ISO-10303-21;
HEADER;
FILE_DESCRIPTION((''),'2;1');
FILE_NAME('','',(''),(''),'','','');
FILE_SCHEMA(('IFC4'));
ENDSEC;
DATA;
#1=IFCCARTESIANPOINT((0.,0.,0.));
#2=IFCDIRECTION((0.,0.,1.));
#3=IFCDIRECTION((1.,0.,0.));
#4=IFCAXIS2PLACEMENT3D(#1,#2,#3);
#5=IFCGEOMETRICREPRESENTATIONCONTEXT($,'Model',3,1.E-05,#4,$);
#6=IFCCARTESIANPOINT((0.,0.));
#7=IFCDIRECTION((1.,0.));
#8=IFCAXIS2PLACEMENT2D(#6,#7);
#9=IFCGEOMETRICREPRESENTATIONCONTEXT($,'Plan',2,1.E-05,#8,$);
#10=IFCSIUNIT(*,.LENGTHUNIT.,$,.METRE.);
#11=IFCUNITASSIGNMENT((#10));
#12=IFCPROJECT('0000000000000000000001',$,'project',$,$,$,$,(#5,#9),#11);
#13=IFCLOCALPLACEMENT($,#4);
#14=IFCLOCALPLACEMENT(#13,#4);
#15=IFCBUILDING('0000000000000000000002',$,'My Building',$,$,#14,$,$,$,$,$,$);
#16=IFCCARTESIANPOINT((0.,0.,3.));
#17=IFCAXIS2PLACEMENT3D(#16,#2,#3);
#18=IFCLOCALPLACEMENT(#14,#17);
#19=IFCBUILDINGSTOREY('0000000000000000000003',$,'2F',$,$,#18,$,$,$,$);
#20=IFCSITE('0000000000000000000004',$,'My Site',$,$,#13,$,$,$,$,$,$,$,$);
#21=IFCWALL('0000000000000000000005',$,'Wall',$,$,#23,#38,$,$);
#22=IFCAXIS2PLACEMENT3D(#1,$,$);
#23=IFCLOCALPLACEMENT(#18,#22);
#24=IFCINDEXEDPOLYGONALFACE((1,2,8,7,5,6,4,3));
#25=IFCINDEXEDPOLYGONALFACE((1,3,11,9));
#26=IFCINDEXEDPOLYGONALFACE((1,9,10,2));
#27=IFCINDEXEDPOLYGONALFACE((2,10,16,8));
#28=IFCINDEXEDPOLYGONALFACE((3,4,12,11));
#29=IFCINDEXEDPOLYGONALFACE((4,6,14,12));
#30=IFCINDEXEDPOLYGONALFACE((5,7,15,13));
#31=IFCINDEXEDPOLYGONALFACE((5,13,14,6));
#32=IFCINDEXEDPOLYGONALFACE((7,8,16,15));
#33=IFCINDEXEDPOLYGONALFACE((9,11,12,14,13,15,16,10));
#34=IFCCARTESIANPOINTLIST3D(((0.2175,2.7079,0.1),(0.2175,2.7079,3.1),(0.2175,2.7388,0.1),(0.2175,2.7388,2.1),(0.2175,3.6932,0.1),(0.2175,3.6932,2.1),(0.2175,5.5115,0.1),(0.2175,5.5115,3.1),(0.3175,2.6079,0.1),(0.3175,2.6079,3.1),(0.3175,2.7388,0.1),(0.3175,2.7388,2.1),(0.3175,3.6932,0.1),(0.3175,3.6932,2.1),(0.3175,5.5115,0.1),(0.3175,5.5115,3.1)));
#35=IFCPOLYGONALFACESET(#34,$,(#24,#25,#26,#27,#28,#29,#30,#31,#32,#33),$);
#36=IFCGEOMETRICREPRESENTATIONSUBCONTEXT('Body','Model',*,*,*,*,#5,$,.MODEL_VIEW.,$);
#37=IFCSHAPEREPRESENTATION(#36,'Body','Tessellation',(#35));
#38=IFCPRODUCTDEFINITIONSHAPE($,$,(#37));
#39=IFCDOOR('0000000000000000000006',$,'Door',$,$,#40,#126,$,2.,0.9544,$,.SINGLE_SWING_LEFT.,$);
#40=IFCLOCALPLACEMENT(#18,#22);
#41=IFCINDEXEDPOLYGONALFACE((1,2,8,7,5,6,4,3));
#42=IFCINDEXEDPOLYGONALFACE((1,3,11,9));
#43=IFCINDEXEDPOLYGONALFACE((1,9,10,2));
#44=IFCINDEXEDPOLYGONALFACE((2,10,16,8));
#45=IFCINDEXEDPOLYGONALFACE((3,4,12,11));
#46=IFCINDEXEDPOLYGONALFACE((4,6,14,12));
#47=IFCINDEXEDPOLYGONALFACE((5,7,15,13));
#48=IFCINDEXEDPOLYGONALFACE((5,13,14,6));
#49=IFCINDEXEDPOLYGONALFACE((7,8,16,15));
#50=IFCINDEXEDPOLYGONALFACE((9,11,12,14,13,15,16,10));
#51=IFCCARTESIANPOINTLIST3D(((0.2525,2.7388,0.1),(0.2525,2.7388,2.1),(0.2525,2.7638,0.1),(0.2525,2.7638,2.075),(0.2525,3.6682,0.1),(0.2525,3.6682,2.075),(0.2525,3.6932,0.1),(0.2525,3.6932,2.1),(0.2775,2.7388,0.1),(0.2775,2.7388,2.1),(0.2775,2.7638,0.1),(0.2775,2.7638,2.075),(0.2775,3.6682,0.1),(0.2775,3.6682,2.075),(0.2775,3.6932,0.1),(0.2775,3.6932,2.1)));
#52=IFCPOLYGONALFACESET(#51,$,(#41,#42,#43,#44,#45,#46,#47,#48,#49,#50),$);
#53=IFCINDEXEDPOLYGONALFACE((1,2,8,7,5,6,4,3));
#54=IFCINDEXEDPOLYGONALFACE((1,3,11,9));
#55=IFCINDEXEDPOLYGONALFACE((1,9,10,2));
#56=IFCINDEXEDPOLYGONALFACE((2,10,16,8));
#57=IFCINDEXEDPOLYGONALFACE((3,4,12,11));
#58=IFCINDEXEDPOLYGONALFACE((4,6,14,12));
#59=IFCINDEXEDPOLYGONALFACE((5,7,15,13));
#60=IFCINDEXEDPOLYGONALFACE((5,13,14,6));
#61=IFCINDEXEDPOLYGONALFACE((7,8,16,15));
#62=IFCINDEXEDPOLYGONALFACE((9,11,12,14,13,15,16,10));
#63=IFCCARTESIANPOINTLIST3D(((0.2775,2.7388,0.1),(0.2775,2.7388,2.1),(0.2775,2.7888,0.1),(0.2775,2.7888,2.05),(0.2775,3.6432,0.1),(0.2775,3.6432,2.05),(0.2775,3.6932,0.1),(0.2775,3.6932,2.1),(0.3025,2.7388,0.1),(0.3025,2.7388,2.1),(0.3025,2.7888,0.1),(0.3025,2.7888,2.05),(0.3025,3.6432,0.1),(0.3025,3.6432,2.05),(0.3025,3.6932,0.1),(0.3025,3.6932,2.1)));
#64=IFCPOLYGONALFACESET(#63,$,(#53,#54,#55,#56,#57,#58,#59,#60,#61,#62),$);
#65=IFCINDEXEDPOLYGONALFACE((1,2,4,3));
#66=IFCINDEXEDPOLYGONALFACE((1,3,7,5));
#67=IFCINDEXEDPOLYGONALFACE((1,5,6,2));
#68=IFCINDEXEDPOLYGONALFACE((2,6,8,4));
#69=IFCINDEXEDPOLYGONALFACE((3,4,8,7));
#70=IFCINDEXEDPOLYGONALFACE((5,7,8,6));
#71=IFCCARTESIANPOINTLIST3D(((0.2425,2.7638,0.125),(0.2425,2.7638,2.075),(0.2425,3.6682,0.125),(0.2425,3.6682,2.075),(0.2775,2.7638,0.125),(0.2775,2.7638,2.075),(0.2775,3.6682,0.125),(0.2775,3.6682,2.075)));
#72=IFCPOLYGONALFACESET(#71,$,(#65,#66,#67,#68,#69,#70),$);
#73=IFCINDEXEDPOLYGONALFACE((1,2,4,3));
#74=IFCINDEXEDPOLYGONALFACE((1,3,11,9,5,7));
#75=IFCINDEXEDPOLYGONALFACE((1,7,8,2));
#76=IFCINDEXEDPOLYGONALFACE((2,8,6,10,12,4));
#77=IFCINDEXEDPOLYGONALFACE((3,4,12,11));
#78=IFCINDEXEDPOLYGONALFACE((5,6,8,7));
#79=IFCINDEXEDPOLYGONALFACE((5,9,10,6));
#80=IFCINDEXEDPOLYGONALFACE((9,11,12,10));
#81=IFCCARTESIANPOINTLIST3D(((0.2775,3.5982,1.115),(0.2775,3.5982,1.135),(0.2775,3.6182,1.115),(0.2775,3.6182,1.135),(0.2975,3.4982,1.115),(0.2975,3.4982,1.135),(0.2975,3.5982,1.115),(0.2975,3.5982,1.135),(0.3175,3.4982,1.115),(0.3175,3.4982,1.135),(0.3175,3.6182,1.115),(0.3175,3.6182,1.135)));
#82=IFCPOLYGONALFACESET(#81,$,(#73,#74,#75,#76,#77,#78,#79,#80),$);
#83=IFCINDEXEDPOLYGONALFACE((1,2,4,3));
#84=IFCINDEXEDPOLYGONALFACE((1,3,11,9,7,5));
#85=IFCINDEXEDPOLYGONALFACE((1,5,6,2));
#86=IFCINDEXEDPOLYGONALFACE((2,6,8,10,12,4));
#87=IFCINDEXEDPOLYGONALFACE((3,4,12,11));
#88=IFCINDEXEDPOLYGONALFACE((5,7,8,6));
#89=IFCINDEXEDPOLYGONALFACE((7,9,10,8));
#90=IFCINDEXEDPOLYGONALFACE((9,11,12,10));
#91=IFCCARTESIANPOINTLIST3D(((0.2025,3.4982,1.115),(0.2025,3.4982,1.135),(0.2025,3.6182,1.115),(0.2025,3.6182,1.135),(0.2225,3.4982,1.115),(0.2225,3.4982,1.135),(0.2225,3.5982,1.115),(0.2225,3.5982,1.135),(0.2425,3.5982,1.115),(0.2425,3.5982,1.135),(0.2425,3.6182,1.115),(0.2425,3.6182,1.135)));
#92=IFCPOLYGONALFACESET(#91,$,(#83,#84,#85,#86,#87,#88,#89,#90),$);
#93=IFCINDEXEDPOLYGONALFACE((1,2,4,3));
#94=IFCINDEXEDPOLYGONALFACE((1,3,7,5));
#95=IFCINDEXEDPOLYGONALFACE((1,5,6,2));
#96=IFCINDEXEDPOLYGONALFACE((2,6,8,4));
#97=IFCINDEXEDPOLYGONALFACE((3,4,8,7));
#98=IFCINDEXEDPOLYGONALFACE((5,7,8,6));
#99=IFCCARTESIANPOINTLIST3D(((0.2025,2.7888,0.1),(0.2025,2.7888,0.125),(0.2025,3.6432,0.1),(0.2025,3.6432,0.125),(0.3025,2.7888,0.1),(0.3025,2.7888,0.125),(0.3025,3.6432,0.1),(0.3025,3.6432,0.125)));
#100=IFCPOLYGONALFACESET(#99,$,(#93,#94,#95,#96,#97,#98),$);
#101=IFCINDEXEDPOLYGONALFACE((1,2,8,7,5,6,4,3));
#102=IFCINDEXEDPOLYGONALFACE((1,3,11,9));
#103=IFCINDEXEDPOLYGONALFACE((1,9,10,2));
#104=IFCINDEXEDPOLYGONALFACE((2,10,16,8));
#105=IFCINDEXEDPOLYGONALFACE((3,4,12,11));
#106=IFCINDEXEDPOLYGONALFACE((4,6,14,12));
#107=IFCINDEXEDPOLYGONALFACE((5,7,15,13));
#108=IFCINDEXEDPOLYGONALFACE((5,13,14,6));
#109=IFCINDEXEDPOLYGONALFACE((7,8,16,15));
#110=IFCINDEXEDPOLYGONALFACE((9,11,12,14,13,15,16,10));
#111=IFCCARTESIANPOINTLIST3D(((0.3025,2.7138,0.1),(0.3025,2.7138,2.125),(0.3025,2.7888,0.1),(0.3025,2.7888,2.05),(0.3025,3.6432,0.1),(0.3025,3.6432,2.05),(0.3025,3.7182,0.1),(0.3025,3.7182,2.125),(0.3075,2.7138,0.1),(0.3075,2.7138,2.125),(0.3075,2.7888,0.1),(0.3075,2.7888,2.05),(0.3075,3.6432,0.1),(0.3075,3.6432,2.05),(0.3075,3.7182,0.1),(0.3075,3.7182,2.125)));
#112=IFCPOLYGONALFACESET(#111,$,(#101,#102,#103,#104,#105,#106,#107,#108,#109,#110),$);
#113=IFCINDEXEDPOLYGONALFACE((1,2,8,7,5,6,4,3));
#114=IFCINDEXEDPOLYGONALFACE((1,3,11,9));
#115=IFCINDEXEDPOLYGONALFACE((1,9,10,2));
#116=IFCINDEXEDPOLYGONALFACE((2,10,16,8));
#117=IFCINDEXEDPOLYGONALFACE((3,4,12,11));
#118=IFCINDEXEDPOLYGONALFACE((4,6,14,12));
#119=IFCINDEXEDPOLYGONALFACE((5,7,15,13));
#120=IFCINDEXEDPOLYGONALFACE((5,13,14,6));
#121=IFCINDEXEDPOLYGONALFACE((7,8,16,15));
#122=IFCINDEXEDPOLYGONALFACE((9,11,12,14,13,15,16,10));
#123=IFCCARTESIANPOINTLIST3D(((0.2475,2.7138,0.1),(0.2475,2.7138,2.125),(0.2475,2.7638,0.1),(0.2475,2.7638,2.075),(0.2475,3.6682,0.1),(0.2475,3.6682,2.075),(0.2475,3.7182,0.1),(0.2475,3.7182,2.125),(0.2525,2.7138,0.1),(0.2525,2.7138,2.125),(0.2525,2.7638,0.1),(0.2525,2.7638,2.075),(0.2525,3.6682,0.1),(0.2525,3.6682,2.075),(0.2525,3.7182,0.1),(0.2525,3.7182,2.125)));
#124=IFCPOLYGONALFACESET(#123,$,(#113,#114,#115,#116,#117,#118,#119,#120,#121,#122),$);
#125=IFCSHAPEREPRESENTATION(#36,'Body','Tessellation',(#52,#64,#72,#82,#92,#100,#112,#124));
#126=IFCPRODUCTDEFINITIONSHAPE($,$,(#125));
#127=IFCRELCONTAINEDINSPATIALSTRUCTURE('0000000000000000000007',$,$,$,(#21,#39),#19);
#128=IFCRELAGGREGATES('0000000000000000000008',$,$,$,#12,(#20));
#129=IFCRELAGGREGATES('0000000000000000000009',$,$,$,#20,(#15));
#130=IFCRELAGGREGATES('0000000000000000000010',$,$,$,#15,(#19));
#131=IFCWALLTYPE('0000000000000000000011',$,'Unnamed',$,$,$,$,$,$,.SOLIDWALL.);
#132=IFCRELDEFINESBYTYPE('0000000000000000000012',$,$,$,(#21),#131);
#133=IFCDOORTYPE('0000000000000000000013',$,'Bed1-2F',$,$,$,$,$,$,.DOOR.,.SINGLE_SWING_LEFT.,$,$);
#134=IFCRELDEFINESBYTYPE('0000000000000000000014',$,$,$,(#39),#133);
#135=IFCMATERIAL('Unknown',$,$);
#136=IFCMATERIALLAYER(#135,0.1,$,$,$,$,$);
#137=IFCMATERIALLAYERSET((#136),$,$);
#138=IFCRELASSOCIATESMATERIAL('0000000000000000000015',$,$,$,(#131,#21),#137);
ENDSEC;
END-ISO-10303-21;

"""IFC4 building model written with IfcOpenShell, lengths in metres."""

from ifc_helpers import new_model, entity, si_unit, frame, origin_with_axes, origin_2d_with_axis, place, context, subcontext, project, spatial, line, indexed_curve, outline, extrude, shape, source, transform, mapped, material, layer, layer_set, layer_usage, type_object, type_shapes, element, fill, save


model = new_model("IFC4")

# Units and contexts
model_context = context("Model", 3, precision=1e-05, world=origin_with_axes())
plan_context = context("Plan", 2, precision=1e-05, world=origin_2d_with_axis())
body_context_1 = subcontext(model_context, "Body", "Model", "MODEL_VIEW")
body_context_2 = subcontext(plan_context, "Body", "Plan", "PLAN_VIEW")
ifc_project = project(units=[si_unit("LENGTHUNIT", "METRE")], contexts=[model_context, plan_context])

# Site, building, storey
site_placement = place(None, origin_with_axes())
site = spatial("IfcSite", under=ifc_project, at=site_placement, Name="My Site")
building_placement = place(site_placement, origin_with_axes())
building = spatial("IfcBuilding", under=site, at=building_placement, Name="My Building")
storey_placement = place(building_placement, frame((0.0, 0.0, 3.0), z_axis=(0.0, 0.0, 1.0), x_axis=(1.0, 0.0, 0.0)))
storey = spatial("IfcBuildingStorey", under=building, at=storey_placement, Name="2F")

# Shared definitions
ifc_material = material(Name="Unknown")

# Shared definitions
ifc_layer_1 = layer(ifc_material, 0.1)
ifc_layer_set_1 = layer_set([ifc_layer_1])
wall_type = type_object("IfcWallType", Name="Unnamed", PredefinedType="SOLIDWALL", material=ifc_layer_set_1)

# Wall, opening, door
ifc_layer_usage_1 = layer_usage(ifc_layer_set_1, "AXIS2", "POSITIVE", 0.0)
wall_1_placement = place(storey_placement, frame((0.3175, 2.7079, 0.1), z_axis=(0.0, 0.0, 1.0), x_axis=(0.0, 1.0, 0.0)))
wall_1 = element("IfcWall", 1, at=wall_1_placement, inside=storey, type_object=wall_type, material=ifc_layer_usage_1, Name="Wall", context=body_context_1, shape_type="SweptSolid", body=[
    extrude(outline(indexed_curve([(-0.1, 0.0), (0.0, 0.1), (2.8037, 0.1), (2.8037, 0.0)], segments=[line(1, 2, 3, 4, 1)])), origin_with_axes(), (0.0, 0.0, 1.0), 3.0),
])
shared_shape_1 = source(origin_with_axes(), body_context_1, "Body", "SweptSolid", [
    extrude(outline(indexed_curve([(0.0, 0.0), (0.9544, 0.0), (0.9544, 2.0), (0.0, 2.0)], segments=[line(1, 2, 3, 4, 1)])), frame((0.0, -0.6, 0.0), z_axis=(0.0, -1.0, 0.0), x_axis=(1.0, 0.0, 0.0)), (0.0, 0.0, -1.0), 1.2),
])
opening_1_placement = place(wall_1_placement, frame((0.0309, 0.015, 0.0), z_axis=(0.0, 0.0, 1.0), x_axis=(1.0, 0.0, 0.0)))
opening_1 = element("IfcOpeningElement", 2, at=opening_1_placement, cuts=wall_1, PredefinedType="OPENING", context=body_context_1, shape_type="MappedRepresentation", body=[
    mapped(shared_shape_1, transform((0.0, 0.0, 0.0), x_axis=(1.0, 0.0, 0.0), y_axis=(0.0, 1.0, 0.0), z_axis=(0.0, 0.0, 1.0), scale=1.0)),
])
door_type_1 = type_object("IfcDoorType", Name="Bed1-2F", OperationType="SINGLE_SWING_LEFT", PredefinedType="DOOR")
shared_shape_2 = source(origin_with_axes(), body_context_1, "Body", "SweptSolid", [
    extrude(outline(indexed_curve([(0.0, 0.0), (0.0, 2.0), (0.9544, 2.0), (0.9544, 0.0), (0.9294, 0.0), (0.9294, 1.975), (0.025, 1.975), (0.025, 0.0)], segments=[line(1, 2, 3, 4, 5, 6, 7, 8, 1)])), frame((0.0, 0.025, 0.0), z_axis=(0.0, -1.0, 0.0), x_axis=(1.0, 0.0, 0.0)), (0.0, 0.0, -1.0), 0.025),
    extrude(outline(indexed_curve([(0.0, 0.0), (0.0, 2.0), (0.9544, 2.0), (0.9544, 0.0), (0.9044, 0.0), (0.9044, 1.95), (0.05, 1.95), (0.05, 0.0)], segments=[line(1, 2, 3, 4, 5, 6, 7, 8, 1)])), frame((0.0, 0.0, 0.0), z_axis=(0.0, -1.0, 0.0), x_axis=(1.0, 0.0, 0.0)), (0.0, 0.0, -1.0), 0.025),
    extrude(outline(indexed_curve([(0.0, 0.0), (0.9044, 0.0), (0.9044, 0.035), (0.0, 0.035)], segments=[line(1, 2, 3, 4, 1)])), frame((0.025, 0.025, 0.025), z_axis=(0.0, 0.0, 1.0), x_axis=(1.0, 0.0, 0.0)), (0.0, 0.0, 1.0), 1.95),
    extrude(outline(indexed_curve([(0.0, 0.0), (0.0, -0.04), (-0.12, -0.04), (-0.12, -0.02), (-0.02, -0.02), (-0.02, 0.0)], segments=[line(1, 2, 3, 4, 5, 6, 1)])), frame((0.8794, 0.025, 1.015), z_axis=(0.0, 0.0, 1.0), x_axis=(1.0, 0.0, 0.0)), (0.0, 0.0, 1.0), 0.02),
    extrude(outline(indexed_curve([(0.0, 0.0), (0.0, 0.04), (-0.12, 0.04), (-0.12, 0.02), (-0.02, 0.02), (-0.02, 0.0)], segments=[line(1, 2, 3, 4, 5, 6, 1)])), frame((0.8794, 0.06, 1.015), z_axis=(0.0, 0.0, 1.0), x_axis=(1.0, 0.0, 0.0)), (0.0, 0.0, 1.0), 0.02),
    extrude(outline(indexed_curve([(0.0, 0.0), (0.8544, 0.0), (0.8544, 0.1), (0.0, 0.1)], segments=[line(1, 2, 3, 4, 1)])), frame((0.05, 0.0, 0.0), z_axis=(0.0, 0.0, 1.0), x_axis=(1.0, 0.0, 0.0)), (0.0, 0.0, 1.0), 0.025),
    extrude(outline(indexed_curve([(0.0, 0.0), (0.0, 2.025), (1.0044, 2.025), (1.0044, 0.0), (0.9294, 0.0), (0.9294, 1.95), (0.075, 1.95), (0.075, 0.0)], segments=[line(1, 2, 3, 4, 5, 6, 7, 8, 1)])), frame((-0.025, -0.005, 0.0), z_axis=(0.0, -1.0, 0.0), x_axis=(1.0, 0.0, 0.0)), (0.0, 0.0, -1.0), 0.005),
    extrude(outline(indexed_curve([(0.0, 0.0), (0.0, 2.025), (1.0044, 2.025), (1.0044, 0.0), (0.9544, 0.0), (0.9544, 1.975), (0.05, 1.975), (0.05, 0.0)], segments=[line(1, 2, 3, 4, 5, 6, 7, 8, 1)])), frame((-0.025, 0.05, 0.0), z_axis=(0.0, -1.0, 0.0), x_axis=(1.0, 0.0, 0.0)), (0.0, 0.0, -1.0), 0.005),
])
shared_shape_3 = source(origin_with_axes(), body_context_2, "Body", "Curve2D", [
    entity("IfcIndexedPolyCurve", entity("IfcCartesianPointList2D", [[0.0, 0.0], [0.0, 0.05], [0.025, 0.05], [0.025, 0.025], [0.05, 0.025], [0.05, 0.0]]), [entity("IfcLineIndex", [1, 2, 3, 4, 5, 6, 1])]),
    entity("IfcIndexedPolyCurve", entity("IfcCartesianPointList2D", [[0.9544, 0.0], [0.9544, 0.05], [0.9294, 0.05], [0.9294, 0.025], [0.9044, 0.025], [0.9044, 0.0]]), [entity("IfcLineIndex", [1, 2, 3, 4, 5, 6, 1])]),
    entity("IfcTrimmedCurve", entity("IfcEllipse", entity("IfcAxis2Placement2D", entity("IfcCartesianPoint", [0.06, 0.05]), entity("IfcDirection", [1.0, 0.0])), 0.8694, 0.9044), [entity("IfcCartesianPoint", [0.9294, 0.05])], [entity("IfcCartesianPoint", [0.06, 0.9544])], True, "CARTESIAN"),
    entity("IfcIndexedPolyCurve", entity("IfcCartesianPointList2D", [[0.025, 0.05], [0.06, 0.05], [0.06, 0.9544], [0.025, 0.9544]]), [entity("IfcLineIndex", [1, 2, 3, 4, 1])]),
])
type_shapes(door_type_1, [shared_shape_2, shared_shape_3])
door_1_placement = place(opening_1_placement, frame((0.0, 0.0, 0.0), z_axis=(0.0, 0.0, 1.0), x_axis=(1.0, 0.0, 0.0)))
door_1 = element("IfcDoor", 3, at=door_1_placement, inside=storey, type_object=door_type_1, Name="Door", OperationType="SINGLE_SWING_LEFT", OverallHeight=2.0, OverallWidth=0.9544, shapes=[
    shape(body_context_1, "Body", "MappedRepresentation", [mapped(shared_shape_2, transform((0.0, 0.0, 0.0), x_axis=(1.0, 0.0, 0.0), y_axis=(0.0, 1.0, 0.0), z_axis=(0.0, 0.0, 1.0), scale=1.0))]),
    shape(body_context_2, "Body", "MappedRepresentation", [mapped(shared_shape_3, transform((0.0, 0.0, 0.0), x_axis=(1.0, 0.0, 0.0), y_axis=(0.0, 1.0, 0.0), z_axis=(0.0, 0.0, 1.0), scale=1.0))]),
])
fill(opening_1, door_1)

save(model, "model.ifc")
